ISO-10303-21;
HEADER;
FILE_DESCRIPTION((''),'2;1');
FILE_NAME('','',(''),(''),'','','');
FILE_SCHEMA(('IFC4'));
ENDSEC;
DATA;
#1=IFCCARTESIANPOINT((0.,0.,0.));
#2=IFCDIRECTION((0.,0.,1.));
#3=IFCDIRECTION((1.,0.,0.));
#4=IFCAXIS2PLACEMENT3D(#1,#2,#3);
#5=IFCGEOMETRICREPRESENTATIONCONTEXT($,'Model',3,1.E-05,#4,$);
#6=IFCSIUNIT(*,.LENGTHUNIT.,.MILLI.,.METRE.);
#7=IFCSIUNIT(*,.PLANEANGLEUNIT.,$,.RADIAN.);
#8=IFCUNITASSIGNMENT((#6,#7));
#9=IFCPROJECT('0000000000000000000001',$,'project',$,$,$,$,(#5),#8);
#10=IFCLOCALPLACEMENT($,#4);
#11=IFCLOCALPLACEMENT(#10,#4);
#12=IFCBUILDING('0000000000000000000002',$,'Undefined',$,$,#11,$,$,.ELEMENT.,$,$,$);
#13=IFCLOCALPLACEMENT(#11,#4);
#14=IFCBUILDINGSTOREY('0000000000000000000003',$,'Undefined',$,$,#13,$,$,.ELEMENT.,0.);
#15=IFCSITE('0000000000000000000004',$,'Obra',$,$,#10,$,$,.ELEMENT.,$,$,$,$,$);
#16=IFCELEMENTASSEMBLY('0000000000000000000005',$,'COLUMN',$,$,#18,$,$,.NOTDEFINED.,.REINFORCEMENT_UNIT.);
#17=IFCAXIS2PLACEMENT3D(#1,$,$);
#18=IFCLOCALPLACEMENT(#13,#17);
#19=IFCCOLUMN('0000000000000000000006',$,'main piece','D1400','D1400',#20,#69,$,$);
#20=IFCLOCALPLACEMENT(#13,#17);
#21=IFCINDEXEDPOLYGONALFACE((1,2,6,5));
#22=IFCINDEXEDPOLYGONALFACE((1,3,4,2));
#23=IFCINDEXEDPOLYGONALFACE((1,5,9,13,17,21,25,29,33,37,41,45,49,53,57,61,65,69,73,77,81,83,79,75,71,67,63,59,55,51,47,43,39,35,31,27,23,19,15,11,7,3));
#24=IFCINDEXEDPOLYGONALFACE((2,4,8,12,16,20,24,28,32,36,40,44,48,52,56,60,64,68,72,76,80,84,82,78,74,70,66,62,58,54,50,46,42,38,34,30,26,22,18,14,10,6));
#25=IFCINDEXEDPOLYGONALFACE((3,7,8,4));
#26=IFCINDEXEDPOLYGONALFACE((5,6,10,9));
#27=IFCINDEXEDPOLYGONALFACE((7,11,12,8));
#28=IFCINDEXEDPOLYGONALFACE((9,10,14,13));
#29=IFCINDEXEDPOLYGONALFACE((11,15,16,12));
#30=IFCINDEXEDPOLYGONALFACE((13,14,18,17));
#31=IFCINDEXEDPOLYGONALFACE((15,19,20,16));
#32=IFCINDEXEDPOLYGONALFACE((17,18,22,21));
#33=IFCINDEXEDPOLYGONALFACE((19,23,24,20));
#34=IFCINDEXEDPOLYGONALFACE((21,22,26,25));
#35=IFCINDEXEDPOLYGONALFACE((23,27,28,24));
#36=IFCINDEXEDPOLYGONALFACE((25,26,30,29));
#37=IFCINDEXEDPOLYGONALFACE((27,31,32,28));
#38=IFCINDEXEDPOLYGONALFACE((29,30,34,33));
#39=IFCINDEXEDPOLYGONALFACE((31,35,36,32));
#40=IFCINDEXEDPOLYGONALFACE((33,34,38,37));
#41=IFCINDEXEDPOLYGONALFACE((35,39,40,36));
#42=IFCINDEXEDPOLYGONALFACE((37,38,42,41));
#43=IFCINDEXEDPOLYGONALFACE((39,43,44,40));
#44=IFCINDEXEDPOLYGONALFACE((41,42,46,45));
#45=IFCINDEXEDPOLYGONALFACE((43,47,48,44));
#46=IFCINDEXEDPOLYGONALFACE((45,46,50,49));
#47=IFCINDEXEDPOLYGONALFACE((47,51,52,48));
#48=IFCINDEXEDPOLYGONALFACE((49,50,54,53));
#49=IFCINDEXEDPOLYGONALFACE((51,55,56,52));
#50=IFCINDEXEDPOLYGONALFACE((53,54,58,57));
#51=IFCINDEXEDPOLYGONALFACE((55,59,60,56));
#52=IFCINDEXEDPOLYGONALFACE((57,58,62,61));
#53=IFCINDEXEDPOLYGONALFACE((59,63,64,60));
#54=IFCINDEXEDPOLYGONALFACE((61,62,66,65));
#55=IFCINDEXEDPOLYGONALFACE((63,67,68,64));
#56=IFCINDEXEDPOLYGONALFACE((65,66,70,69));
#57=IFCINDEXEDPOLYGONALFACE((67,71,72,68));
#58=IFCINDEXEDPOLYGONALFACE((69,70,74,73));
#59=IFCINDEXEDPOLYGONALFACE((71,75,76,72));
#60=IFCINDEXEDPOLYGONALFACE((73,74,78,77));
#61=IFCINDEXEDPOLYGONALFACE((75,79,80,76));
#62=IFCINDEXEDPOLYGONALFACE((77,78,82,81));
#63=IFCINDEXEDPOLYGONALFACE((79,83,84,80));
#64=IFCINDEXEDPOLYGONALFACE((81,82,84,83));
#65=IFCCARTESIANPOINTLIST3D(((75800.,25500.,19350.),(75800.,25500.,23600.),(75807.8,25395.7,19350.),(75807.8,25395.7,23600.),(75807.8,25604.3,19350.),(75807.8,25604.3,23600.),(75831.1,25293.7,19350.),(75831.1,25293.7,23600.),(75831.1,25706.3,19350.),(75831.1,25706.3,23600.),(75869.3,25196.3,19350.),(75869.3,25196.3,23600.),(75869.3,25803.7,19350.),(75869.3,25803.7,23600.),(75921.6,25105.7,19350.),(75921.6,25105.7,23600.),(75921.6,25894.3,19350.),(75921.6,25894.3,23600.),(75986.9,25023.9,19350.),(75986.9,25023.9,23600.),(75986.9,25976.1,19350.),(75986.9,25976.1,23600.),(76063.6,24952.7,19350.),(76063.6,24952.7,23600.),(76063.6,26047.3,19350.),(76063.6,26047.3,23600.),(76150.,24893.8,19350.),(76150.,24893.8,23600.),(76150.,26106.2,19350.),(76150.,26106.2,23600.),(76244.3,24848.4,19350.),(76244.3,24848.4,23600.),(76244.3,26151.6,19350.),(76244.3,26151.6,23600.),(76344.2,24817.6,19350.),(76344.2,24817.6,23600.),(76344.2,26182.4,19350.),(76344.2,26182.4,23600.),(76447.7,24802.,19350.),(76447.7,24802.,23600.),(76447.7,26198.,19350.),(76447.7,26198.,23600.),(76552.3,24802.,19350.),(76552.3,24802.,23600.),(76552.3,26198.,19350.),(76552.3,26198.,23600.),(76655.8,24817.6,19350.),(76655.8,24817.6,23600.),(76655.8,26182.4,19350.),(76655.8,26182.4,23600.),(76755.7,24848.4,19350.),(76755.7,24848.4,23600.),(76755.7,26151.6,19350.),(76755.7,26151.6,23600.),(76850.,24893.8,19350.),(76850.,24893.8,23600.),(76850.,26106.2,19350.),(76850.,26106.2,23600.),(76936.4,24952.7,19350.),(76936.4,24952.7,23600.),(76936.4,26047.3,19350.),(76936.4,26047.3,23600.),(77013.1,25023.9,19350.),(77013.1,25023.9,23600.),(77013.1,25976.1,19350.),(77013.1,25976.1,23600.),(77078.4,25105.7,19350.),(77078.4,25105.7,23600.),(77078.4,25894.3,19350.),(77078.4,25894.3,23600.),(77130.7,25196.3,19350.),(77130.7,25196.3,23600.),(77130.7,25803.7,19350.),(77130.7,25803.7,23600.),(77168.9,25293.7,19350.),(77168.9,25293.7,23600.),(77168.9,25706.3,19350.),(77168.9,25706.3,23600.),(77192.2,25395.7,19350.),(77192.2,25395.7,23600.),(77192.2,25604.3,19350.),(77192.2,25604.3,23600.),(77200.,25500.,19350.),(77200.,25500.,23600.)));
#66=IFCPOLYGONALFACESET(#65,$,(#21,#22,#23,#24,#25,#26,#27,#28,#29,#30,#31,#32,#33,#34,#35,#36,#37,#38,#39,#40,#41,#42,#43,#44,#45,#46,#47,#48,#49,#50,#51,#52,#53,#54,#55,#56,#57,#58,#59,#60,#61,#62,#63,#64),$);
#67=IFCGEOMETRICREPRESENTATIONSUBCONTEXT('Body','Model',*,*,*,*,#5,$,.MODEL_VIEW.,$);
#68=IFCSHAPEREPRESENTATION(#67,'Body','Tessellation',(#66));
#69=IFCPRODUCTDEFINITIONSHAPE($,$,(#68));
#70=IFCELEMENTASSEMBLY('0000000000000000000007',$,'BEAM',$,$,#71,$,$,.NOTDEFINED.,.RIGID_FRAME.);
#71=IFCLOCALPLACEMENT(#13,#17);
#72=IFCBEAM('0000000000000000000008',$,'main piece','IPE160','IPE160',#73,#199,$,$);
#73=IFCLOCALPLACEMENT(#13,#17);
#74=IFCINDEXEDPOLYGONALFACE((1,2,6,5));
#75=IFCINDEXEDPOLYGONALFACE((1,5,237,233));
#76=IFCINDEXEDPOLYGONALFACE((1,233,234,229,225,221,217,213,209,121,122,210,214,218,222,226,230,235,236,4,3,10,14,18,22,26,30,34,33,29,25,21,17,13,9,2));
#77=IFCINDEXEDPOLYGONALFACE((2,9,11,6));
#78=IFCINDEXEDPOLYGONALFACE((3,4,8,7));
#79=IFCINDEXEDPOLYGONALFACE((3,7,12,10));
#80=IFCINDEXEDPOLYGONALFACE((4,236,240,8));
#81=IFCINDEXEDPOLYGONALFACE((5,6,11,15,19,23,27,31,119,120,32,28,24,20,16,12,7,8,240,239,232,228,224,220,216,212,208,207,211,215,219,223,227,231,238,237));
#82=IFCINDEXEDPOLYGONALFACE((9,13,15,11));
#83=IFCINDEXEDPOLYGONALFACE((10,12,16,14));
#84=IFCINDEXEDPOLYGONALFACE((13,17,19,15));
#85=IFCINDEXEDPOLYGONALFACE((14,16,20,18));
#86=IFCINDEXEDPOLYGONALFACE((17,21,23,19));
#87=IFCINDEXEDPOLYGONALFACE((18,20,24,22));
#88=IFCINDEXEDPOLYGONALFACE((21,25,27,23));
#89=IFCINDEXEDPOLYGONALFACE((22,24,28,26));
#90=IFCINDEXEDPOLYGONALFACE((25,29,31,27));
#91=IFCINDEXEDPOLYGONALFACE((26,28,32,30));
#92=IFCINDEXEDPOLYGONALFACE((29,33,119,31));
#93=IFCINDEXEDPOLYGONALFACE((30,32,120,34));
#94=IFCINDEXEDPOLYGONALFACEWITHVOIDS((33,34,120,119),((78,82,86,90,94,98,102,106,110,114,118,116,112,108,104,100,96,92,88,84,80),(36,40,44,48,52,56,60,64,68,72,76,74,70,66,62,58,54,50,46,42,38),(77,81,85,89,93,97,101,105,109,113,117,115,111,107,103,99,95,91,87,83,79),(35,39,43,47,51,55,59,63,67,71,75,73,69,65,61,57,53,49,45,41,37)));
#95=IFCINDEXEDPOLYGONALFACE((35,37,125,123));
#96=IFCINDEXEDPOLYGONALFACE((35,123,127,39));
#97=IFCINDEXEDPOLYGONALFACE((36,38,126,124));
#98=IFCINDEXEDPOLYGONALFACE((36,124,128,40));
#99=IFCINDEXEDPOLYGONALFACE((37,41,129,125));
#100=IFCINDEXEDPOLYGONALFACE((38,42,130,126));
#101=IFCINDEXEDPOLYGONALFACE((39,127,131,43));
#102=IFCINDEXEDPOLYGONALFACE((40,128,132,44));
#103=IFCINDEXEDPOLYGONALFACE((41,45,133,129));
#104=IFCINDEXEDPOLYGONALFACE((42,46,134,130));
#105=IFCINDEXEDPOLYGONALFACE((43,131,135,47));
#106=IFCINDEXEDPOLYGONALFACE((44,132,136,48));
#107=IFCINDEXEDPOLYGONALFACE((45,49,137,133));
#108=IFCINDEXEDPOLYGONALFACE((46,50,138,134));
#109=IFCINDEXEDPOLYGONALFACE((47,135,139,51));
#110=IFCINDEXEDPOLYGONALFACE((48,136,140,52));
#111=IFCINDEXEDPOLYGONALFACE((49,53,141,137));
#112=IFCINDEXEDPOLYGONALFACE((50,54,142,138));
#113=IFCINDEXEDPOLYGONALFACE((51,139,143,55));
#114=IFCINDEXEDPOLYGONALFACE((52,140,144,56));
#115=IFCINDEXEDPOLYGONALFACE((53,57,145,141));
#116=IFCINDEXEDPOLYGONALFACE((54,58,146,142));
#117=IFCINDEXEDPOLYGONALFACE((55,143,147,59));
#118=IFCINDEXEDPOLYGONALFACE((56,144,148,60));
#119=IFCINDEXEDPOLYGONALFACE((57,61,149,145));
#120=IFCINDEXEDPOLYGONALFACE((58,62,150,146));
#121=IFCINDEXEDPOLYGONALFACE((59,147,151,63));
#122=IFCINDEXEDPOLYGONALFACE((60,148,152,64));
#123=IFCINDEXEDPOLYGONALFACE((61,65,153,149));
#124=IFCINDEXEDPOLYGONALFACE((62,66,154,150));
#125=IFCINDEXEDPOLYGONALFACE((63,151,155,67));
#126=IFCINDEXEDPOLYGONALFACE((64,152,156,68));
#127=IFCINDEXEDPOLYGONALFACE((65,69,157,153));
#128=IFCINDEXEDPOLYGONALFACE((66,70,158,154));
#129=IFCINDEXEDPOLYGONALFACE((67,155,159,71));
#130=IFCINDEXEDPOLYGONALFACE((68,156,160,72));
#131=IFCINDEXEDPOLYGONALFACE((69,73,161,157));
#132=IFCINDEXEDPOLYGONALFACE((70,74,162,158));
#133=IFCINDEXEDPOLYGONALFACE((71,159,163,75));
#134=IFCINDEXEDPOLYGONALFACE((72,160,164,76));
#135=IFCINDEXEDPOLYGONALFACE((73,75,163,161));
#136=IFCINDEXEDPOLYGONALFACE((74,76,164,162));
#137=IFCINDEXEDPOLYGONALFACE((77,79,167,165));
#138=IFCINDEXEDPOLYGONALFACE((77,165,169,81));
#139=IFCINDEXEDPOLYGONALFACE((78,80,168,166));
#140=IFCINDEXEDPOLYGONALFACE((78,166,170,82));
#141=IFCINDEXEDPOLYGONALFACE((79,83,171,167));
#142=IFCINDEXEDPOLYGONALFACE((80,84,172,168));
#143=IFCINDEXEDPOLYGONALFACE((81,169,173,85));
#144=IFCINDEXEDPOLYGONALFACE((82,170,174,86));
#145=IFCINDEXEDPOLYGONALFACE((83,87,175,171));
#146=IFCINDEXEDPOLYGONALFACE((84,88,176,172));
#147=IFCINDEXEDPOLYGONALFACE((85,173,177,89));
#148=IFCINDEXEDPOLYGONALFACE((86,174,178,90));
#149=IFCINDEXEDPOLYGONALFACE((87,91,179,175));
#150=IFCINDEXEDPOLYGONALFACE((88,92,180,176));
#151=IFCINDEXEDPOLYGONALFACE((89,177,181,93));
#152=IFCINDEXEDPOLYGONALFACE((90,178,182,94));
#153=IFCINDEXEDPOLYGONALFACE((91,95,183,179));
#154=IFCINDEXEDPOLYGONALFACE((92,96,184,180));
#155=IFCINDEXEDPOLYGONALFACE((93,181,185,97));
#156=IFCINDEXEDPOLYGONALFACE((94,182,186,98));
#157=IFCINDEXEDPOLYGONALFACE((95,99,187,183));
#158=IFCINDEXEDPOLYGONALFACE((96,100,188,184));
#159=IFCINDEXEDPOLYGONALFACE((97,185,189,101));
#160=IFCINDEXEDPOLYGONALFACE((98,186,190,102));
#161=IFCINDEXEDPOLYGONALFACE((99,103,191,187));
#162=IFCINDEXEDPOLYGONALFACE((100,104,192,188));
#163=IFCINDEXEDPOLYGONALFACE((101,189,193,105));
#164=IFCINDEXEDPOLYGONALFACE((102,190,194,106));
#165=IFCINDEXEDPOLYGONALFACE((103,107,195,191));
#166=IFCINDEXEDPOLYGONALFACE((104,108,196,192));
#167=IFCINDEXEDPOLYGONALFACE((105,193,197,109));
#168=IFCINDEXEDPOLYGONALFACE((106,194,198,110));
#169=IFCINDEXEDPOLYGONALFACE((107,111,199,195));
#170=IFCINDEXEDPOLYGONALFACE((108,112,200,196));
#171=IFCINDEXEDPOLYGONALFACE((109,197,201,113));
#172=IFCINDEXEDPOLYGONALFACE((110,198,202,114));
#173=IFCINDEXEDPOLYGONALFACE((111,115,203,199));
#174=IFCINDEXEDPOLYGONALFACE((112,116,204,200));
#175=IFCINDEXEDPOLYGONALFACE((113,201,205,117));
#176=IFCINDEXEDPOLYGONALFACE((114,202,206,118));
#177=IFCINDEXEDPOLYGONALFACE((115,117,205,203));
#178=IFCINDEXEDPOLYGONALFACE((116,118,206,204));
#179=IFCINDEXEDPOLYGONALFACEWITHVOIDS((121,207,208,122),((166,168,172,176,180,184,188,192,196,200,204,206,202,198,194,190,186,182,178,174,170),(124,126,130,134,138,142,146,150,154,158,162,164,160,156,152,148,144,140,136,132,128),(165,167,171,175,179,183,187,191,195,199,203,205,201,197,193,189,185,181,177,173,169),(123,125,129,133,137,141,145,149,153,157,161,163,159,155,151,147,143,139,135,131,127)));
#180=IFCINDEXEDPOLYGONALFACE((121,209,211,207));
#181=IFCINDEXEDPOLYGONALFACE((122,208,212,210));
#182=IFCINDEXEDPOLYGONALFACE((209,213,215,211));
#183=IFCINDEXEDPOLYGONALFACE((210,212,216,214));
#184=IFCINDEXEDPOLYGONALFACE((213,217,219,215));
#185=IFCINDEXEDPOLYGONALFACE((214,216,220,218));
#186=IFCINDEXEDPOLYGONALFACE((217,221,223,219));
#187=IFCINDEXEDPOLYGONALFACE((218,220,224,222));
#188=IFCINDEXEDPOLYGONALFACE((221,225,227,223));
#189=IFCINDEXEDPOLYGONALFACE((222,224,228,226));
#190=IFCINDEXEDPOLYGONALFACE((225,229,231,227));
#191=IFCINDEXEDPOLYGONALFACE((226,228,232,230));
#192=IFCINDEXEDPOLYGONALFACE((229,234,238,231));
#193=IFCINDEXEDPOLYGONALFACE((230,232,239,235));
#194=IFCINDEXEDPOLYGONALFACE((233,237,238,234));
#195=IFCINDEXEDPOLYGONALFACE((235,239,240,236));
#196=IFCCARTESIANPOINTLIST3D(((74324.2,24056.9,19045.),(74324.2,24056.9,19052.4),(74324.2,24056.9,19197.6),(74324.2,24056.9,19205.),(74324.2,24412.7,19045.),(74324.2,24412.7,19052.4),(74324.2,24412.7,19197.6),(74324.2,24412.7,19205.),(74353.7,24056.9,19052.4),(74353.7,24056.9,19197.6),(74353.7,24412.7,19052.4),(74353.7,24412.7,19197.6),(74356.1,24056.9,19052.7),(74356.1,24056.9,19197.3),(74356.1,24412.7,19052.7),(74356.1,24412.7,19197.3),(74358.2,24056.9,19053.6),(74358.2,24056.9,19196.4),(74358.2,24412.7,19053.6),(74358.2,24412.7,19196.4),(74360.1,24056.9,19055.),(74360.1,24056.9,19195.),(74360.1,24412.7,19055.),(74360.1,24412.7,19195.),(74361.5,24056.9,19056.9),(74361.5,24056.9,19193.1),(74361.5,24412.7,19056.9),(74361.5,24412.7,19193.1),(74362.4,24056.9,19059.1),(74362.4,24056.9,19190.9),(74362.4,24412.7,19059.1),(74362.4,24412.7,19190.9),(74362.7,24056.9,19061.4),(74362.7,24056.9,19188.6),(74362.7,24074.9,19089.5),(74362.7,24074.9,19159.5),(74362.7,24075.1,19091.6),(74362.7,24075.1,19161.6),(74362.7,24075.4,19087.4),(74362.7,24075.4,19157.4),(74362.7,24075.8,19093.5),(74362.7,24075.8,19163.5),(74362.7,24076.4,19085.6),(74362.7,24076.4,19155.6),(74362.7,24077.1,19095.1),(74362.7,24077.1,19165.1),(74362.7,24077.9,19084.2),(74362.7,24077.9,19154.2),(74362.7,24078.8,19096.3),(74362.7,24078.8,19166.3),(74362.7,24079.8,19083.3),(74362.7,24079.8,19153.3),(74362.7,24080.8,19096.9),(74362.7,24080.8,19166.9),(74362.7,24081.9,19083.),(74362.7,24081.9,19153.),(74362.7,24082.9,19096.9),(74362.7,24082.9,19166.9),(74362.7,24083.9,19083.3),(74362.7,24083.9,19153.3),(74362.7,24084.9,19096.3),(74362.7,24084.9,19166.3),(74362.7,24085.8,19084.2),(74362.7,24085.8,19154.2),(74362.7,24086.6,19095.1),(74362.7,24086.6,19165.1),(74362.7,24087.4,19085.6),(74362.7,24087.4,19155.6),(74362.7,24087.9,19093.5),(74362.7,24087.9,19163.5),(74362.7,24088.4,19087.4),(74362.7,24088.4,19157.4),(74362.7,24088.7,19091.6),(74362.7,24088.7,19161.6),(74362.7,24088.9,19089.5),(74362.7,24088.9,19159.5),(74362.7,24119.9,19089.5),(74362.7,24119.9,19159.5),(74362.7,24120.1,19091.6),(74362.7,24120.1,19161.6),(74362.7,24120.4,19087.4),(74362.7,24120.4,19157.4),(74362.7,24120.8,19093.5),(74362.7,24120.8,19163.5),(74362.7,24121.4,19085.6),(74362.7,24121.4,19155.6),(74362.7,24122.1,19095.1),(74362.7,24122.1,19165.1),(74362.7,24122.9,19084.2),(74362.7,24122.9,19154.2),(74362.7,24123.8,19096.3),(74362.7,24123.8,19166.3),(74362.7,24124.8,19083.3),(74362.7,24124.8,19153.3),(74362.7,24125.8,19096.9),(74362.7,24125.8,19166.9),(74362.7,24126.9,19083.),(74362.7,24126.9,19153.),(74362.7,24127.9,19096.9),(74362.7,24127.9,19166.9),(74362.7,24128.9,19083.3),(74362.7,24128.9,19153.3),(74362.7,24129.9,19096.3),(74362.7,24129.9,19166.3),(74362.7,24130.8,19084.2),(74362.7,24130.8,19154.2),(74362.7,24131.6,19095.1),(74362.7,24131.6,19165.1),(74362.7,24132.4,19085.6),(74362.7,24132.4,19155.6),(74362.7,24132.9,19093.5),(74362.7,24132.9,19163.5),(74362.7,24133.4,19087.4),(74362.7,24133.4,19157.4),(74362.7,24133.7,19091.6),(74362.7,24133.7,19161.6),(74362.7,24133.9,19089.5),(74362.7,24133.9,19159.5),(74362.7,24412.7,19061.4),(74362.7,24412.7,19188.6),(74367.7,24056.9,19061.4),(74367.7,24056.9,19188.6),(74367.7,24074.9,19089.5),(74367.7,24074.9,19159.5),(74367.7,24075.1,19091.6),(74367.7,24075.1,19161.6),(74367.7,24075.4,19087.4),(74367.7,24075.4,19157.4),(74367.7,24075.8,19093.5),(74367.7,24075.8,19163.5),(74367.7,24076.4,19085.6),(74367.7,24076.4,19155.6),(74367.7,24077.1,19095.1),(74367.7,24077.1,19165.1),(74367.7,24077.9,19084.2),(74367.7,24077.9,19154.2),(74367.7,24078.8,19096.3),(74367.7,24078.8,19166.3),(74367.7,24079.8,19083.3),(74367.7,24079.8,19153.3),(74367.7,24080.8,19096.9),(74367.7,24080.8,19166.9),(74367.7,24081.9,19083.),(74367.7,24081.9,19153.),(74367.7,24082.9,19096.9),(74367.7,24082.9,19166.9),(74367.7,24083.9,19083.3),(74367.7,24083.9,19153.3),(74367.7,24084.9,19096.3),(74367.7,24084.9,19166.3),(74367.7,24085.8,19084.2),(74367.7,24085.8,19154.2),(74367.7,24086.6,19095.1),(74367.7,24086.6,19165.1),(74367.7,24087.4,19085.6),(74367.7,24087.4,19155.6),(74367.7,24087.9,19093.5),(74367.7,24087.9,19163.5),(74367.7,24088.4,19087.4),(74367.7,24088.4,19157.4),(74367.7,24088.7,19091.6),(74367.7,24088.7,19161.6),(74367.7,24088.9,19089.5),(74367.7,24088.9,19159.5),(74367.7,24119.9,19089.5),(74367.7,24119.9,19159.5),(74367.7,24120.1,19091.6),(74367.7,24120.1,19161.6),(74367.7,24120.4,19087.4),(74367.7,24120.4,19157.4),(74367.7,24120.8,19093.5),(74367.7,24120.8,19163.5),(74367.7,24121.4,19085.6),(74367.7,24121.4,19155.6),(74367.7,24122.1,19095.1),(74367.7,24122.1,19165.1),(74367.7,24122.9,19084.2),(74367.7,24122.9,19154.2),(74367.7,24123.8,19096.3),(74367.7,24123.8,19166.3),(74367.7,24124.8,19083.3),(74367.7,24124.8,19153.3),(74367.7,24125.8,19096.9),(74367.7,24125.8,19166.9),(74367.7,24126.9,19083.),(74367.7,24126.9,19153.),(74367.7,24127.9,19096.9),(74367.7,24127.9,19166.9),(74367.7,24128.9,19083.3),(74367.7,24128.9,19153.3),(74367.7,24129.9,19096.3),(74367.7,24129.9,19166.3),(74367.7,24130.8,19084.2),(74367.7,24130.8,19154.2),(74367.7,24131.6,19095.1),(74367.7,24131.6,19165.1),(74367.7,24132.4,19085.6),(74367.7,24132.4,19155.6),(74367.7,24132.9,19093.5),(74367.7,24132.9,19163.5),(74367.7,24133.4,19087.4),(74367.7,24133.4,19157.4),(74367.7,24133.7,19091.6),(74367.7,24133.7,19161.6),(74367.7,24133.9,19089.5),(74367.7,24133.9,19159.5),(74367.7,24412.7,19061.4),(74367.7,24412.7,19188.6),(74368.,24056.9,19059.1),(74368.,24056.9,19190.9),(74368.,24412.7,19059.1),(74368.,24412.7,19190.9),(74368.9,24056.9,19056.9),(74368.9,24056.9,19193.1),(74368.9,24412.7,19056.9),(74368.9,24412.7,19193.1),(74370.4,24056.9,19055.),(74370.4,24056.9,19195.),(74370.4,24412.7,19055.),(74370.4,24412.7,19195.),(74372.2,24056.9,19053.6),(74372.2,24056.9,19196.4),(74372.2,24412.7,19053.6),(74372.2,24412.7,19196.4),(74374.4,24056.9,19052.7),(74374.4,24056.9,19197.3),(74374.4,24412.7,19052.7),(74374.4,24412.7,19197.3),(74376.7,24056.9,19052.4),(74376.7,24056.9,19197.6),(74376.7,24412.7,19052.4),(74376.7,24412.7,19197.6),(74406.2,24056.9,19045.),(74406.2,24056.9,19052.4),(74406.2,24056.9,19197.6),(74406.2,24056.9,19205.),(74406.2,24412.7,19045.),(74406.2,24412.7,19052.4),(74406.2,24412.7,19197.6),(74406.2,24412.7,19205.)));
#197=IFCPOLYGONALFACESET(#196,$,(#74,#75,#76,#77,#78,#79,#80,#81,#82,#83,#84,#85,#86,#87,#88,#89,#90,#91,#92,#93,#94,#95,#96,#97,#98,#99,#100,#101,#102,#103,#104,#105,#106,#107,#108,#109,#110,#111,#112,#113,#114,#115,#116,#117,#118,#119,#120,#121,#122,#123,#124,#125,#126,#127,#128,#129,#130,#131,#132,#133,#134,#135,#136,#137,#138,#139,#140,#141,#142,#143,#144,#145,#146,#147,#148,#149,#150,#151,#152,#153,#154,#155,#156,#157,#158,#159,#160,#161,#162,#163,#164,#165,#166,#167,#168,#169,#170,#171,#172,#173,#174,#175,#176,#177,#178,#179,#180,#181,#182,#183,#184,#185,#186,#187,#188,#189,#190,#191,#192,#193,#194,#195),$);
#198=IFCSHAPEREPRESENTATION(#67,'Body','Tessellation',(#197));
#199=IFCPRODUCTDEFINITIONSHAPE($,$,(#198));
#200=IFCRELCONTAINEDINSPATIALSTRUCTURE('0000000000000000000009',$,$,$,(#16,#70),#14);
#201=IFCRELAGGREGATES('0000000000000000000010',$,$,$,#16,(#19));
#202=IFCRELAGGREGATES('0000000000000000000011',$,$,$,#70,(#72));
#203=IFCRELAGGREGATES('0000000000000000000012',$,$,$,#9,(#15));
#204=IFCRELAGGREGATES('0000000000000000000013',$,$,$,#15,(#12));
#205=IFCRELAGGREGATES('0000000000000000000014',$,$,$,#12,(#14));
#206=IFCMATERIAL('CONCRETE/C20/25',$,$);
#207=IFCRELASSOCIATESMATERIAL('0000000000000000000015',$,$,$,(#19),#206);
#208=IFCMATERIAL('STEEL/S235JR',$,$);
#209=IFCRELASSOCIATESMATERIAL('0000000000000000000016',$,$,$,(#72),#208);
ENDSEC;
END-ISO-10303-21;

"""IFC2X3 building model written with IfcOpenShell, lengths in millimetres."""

from ifc_helpers import new_model, si_unit, frame, origin_with_axes, origin_2d_with_axis, place, context, subcontext, project, spatial, circle, i_section, extrude, clip, halfspace, source, transform, mapped, material, element, aggregate, save


model = new_model("IFC2X3")

# Units and contexts
model_context = context("Model", 3, precision=1e-05, world=origin_with_axes())
body_context = subcontext(model_context, "Body", "Model", "MODEL_VIEW")
ifc_project = project(units=[si_unit("LENGTHUNIT", "METRE", prefix="MILLI"), si_unit("PLANEANGLEUNIT", "RADIAN")], contexts=[model_context])

# Site, building, storey
site_placement = place(None, origin_with_axes())
site = spatial("IfcSite", under=ifc_project, at=site_placement, Name="Obra", CompositionType="ELEMENT")
building_placement = place(site_placement, origin_with_axes())
building = spatial("IfcBuilding", under=site, at=building_placement, Name="Undefined", CompositionType="ELEMENT")
storey_placement = place(building_placement, origin_with_axes())
storey = spatial("IfcBuildingStorey", under=building, at=storey_placement, Name="Undefined", CompositionType="ELEMENT", Elevation=0.0)

# Element assembly, column
assembly_1_placement = place(storey_placement, origin_with_axes())
assembly_1 = element("IfcElementAssembly", 1, at=assembly_1_placement, inside=storey, Name="COLUMN", AssemblyPlace="NOTDEFINED", PredefinedType="REINFORCEMENT_UNIT")
ifc_material_1 = material(Name="CONCRETE/C20/25")
column_placement = place(assembly_1_placement, frame((76500.0, 25500.0, 19350.0), z_axis=(0.0, 0.0, 1.0), x_axis=(0.0, 1.0, 0.0)))
column = element("IfcColumn", 2, at=column_placement, material=ifc_material_1, Name="main piece", Description="D1400", ObjectType="D1400", context=body_context, shape_type="SweptSolid", body=[
    extrude(circle(Radius=700.0, at=origin_2d_with_axis()), frame((0.0, 0.0, 4250.0), z_axis=(0.0, 0.0, -1.0), x_axis=(0.0, 1.0, 0.0)), (0.0, 0.0, 1.0), 4250.0),
])
aggregate(assembly_1, [column])

# Element assembly, beam, opening
assembly_2_placement = place(storey_placement, origin_with_axes())
assembly_2 = element("IfcElementAssembly", 3, at=assembly_2_placement, inside=storey, Name="BEAM", AssemblyPlace="NOTDEFINED", PredefinedType="RIGID_FRAME")
ifc_material_2 = material(Name="STEEL/S235JR")
beam_1_placement = place(assembly_2_placement, frame((74365.2, 23901.0, 19125.0), z_axis=(0.0, 0.0, 1.0), x_axis=(0.0, 1.0, 0.0)))
beam_1 = element("IfcBeam", 4, at=beam_1_placement, material=ifc_material_2, Name="main piece", Description="IPE160", ObjectType="IPE160", context=body_context, shape_type="Clipping", body=[
    clip(extrude(i_section(OverallWidth=82.0, OverallDepth=160.0, WebThickness=5.0, FlangeThickness=7.4, FilletRadius=9.0, at=origin_2d_with_axis()), frame((511.7, 0.0, 0.0), z_axis=(-1.0, 0.0, 0.0), x_axis=(0.0, -1.0, 0.0)), (0.0, 0.0, 1.0), 355.8), halfspace(frame((155.9, 0.0, -180.0), z_axis=(1.0, 0.0, 0.0), x_axis=(0.0, -1.0, 0.0)), True)),
])
shared_shape_1 = source(origin_with_axes(), body_context, "Body", "SweptSolid", [
    extrude(circle(Radius=7.0, at=origin_2d_with_axis()), frame((0.0, -2.6, 0.0), z_axis=(0.0, 1.0, 0.0), x_axis=(1.0, 0.0, 0.0)), (0.0, 0.0, 1.0), 5.2),
])
opening_1_placement = place(assembly_2_placement, frame((74365.2, 24056.9, 19185.0), z_axis=(0.0, 1.0, 0.0), x_axis=(0.0, 0.0, -1.0)))
element("IfcOpeningElement", 5, at=opening_1_placement, cuts=beam_1, ObjectType="Opening", context=body_context, shape_type="MappedRepresentation", body=[
    mapped(shared_shape_1, transform((25.0, 0.0, 25.0))),
    mapped(shared_shape_1, transform((25.0, 0.0, 70.0))),
    mapped(shared_shape_1, transform((95.0, 0.0, 25.0))),
    mapped(shared_shape_1, transform((95.0, 0.0, 70.0))),
])

aggregate(assembly_2, [beam_1])

save(model, "model.ifc")
